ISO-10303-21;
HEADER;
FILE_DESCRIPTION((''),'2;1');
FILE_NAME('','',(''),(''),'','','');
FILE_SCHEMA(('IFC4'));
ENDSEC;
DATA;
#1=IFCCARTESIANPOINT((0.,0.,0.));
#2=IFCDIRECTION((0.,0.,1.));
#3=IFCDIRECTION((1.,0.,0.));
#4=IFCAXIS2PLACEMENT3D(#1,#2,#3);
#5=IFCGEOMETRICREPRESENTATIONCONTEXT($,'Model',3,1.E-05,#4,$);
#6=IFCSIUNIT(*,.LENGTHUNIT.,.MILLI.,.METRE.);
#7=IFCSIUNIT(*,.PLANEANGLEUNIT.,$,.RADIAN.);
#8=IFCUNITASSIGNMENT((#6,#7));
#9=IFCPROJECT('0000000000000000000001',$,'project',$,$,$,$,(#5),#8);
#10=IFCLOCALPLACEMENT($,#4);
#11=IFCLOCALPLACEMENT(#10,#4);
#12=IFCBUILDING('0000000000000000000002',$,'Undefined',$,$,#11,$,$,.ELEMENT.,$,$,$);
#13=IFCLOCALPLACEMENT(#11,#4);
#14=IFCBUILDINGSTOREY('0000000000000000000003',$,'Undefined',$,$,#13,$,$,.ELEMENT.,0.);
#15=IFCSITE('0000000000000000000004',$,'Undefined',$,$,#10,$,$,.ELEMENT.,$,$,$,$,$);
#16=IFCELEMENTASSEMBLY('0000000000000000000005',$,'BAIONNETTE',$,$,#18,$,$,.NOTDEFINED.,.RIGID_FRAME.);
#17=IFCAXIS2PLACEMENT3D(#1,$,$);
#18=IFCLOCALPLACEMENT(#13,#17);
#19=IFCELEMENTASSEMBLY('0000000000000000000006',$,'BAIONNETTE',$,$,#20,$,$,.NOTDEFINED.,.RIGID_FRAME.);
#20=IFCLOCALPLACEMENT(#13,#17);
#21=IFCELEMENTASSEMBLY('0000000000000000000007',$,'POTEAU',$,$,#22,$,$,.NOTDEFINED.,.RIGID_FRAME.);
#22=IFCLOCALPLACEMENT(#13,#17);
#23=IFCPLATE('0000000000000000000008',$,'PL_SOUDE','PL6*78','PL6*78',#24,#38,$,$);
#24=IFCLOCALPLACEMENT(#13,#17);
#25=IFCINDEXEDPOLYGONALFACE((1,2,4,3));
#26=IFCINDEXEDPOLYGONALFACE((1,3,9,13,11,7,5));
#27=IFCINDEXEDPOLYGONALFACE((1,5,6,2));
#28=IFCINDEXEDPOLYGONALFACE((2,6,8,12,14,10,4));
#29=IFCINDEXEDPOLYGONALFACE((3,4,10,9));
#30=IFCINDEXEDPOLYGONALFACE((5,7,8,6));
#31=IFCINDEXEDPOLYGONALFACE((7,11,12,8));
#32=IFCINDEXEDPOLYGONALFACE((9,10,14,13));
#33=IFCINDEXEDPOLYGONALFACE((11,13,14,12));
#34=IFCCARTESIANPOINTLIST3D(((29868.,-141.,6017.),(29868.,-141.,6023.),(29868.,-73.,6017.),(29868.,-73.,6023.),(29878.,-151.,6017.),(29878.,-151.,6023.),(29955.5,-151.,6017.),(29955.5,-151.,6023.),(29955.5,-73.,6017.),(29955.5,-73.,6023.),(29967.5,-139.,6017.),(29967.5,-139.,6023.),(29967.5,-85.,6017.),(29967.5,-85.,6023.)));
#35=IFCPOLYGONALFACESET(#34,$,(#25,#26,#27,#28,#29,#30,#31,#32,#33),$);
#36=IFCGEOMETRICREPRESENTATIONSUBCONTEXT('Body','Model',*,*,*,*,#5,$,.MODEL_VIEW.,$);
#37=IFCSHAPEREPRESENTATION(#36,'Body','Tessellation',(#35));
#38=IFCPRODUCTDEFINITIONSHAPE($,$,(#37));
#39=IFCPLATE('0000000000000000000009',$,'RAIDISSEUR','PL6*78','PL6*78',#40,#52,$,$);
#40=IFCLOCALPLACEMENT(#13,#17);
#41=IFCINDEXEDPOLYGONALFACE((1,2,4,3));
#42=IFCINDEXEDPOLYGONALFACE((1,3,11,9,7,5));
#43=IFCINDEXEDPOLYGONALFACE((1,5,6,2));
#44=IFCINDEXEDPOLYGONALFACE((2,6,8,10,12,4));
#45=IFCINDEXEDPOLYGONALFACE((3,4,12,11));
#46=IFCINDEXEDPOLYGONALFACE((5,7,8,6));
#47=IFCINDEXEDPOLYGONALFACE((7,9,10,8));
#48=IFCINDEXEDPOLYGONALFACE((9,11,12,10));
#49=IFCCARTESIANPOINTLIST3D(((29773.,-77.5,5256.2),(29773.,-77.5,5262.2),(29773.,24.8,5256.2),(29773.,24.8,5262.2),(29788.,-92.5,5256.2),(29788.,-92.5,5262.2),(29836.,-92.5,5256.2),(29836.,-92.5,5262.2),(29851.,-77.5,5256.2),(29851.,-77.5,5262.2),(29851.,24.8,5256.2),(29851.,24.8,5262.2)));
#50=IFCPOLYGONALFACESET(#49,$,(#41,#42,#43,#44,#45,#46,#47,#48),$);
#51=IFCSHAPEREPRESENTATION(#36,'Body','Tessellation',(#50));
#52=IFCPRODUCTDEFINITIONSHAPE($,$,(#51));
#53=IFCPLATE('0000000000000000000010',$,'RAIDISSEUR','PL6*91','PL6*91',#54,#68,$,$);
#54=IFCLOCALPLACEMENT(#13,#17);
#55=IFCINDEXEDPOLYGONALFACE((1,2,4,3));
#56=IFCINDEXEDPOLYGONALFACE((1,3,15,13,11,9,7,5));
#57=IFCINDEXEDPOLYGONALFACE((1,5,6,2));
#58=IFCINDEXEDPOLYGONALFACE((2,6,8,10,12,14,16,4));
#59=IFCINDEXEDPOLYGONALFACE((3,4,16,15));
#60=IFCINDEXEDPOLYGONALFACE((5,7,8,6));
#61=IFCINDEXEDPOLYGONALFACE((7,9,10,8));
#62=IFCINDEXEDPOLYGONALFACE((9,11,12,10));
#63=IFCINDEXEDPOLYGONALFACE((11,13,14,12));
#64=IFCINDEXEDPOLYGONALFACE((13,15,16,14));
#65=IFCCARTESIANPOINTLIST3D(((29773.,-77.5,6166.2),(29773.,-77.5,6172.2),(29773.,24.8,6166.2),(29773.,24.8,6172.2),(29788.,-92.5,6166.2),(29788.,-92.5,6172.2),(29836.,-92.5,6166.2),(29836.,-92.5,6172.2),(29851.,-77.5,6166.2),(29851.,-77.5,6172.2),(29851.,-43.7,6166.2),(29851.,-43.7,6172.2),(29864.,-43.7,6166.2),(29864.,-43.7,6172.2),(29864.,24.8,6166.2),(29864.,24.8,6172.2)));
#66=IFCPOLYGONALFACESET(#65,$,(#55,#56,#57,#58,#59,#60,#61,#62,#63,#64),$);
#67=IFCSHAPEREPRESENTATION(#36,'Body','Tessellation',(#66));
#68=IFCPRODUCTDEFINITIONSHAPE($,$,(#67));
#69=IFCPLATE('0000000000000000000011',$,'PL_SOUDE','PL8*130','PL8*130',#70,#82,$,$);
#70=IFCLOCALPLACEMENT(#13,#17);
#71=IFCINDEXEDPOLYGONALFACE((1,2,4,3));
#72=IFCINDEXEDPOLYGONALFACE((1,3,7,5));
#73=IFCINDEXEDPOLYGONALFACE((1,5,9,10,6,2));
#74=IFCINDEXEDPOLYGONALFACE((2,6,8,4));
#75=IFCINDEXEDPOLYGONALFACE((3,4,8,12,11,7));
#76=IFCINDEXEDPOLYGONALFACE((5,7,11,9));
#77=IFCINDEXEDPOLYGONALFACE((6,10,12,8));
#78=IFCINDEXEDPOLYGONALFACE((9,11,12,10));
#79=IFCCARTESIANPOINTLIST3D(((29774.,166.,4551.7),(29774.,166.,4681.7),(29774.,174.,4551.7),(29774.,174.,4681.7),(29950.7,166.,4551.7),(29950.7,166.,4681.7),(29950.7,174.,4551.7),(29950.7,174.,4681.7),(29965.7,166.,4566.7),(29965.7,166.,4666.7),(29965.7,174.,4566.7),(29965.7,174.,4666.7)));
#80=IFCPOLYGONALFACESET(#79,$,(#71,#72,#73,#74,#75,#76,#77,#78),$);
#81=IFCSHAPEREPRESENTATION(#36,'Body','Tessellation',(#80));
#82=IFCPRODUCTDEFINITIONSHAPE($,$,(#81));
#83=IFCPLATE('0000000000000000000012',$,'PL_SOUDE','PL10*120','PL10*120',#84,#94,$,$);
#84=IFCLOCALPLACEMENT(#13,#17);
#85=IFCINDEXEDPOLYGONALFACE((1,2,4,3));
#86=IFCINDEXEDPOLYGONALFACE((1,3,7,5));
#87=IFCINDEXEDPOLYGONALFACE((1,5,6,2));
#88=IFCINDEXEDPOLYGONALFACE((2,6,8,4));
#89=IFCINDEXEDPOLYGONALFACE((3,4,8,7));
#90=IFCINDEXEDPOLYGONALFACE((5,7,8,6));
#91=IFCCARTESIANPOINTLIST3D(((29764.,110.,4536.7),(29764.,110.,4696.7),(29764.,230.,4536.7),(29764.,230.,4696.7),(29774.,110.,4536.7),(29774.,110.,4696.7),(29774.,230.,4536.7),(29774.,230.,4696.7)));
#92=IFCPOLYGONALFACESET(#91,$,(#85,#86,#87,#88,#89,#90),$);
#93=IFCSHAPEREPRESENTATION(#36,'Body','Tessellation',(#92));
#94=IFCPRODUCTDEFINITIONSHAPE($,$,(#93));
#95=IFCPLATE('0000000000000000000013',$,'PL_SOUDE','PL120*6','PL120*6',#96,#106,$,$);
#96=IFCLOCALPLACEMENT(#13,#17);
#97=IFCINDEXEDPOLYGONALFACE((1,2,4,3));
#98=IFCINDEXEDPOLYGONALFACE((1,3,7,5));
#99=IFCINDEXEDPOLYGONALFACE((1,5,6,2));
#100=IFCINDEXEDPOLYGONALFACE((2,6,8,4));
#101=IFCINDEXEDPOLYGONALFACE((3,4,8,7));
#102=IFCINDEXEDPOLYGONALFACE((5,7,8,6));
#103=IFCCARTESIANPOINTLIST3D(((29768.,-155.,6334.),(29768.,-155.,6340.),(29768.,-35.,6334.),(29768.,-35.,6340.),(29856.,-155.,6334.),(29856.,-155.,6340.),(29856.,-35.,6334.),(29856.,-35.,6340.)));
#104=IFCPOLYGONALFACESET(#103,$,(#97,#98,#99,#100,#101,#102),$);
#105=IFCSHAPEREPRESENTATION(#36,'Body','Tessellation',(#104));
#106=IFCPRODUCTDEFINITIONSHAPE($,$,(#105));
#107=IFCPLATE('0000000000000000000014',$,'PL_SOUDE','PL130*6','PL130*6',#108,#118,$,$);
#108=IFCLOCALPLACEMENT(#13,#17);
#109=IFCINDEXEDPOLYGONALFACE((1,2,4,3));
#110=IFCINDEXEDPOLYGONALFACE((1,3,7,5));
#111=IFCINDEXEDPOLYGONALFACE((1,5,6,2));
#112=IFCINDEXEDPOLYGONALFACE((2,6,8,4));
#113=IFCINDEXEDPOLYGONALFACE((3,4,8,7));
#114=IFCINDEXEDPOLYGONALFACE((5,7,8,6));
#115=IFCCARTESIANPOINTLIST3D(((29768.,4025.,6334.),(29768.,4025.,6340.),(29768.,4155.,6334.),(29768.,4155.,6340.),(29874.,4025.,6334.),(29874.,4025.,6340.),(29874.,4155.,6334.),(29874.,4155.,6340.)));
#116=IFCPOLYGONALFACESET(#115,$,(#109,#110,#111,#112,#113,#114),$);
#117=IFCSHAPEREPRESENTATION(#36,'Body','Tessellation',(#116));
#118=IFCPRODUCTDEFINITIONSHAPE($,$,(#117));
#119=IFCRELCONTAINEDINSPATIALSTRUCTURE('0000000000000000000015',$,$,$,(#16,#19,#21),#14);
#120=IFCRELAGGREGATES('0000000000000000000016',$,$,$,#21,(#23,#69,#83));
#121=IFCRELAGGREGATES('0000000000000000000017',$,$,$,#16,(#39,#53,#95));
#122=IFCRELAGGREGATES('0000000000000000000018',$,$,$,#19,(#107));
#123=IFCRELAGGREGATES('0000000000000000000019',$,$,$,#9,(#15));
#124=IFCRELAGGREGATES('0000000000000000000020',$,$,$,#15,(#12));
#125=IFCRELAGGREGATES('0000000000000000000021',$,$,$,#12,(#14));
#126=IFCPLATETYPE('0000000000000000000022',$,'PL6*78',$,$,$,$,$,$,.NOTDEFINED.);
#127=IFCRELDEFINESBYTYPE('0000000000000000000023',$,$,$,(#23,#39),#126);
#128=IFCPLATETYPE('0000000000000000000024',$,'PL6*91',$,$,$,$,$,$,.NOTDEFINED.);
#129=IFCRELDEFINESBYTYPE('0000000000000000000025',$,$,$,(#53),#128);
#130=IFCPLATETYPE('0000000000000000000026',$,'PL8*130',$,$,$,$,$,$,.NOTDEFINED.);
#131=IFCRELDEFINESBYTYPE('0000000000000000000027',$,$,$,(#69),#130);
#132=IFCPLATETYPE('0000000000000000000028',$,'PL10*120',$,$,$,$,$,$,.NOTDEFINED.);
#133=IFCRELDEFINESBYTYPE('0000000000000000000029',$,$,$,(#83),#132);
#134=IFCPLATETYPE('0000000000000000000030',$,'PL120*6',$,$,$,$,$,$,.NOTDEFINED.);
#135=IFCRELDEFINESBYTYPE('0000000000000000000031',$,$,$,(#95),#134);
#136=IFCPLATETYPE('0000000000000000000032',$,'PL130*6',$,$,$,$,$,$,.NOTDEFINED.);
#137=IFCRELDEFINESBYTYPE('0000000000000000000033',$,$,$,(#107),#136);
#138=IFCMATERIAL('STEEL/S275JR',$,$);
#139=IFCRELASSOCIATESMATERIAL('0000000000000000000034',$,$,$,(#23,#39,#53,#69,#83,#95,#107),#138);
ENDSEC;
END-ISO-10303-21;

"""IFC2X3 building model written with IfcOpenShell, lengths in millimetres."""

from ifc_helpers import new_model, si_unit, frame, origin_with_axes, place, context, subcontext, project, spatial, polyline, outline, extrude, material, type_object, element, aggregate, save


model = new_model("IFC2X3")

# Units and contexts
model_context = context("Model", 3, precision=1e-05, world=origin_with_axes())
body_context = subcontext(model_context, "Body", "Model", "MODEL_VIEW")
ifc_project = project(units=[si_unit("LENGTHUNIT", "METRE", prefix="MILLI"), si_unit("PLANEANGLEUNIT", "RADIAN")], contexts=[model_context])

# Site, building, storey
site_placement = place(None, origin_with_axes())
site = spatial("IfcSite", under=ifc_project, at=site_placement, Name="Undefined", CompositionType="ELEMENT")
building_placement = place(site_placement, origin_with_axes())
building = spatial("IfcBuilding", under=site, at=building_placement, Name="Undefined", CompositionType="ELEMENT")
storey_placement = place(building_placement, origin_with_axes())
storey = spatial("IfcBuildingStorey", under=building, at=storey_placement, Name="Undefined", CompositionType="ELEMENT", Elevation=0.0)

# Shared definitions
ifc_material_1 = material(Name="STEEL/S275JR")

# Element assemblies
assembly_1_placement = place(storey_placement, origin_with_axes())
assembly_1 = element("IfcElementAssembly", 1, at=assembly_1_placement, inside=storey, Name="BAIONNETTE", AssemblyPlace="NOTDEFINED", PredefinedType="RIGID_FRAME")
assembly_2_placement = place(storey_placement, origin_with_axes())
assembly_2 = element("IfcElementAssembly", 2, at=assembly_2_placement, inside=storey, Name="BAIONNETTE", AssemblyPlace="NOTDEFINED", PredefinedType="RIGID_FRAME")

# Element assembly, plate
assembly_3_placement = place(storey_placement, origin_with_axes())
assembly_3 = element("IfcElementAssembly", 3, at=assembly_3_placement, inside=storey, Name="POTEAU", AssemblyPlace="NOTDEFINED", PredefinedType="RIGID_FRAME")
plate_type_1 = type_object("IfcPlateType", Name="PL6*78", PredefinedType="NOTDEFINED")
plate_1_placement = place(assembly_3_placement, frame((29868.0, -151.0, 6020.0), z_axis=(0.0, 0.0, 1.0), x_axis=(1.0, 0.0, 0.0)))
plate_1 = element("IfcPlate", 4, at=plate_1_placement, type_object=plate_type_1, material=ifc_material_1, Name="PL_SOUDE", Description="PL6*78", ObjectType="PL6*78", context=body_context, shape_type="SweptSolid", body=[
    extrude(outline(polyline([(0.0, 10.0), (10.0, 0.0), (87.5, 0.0), (99.5, 12.0), (99.5, 66.0), (87.5, 78.0), (0.0, 78.0), (0.0, 10.0)])), frame((0.0, 0.0, -3.0), z_axis=(0.0, 0.0, 1.0), x_axis=(1.0, 0.0, 0.0)), (0.0, 0.0, 1.0), 6.0),
])

# Plates
plate_2_placement = place(assembly_1_placement, frame((29851.0, -92.5, 5259.2), z_axis=(0.0, 0.0, 1.0), x_axis=(0.0, 1.0, 0.0)))
plate_2 = element("IfcPlate", 5, at=plate_2_placement, type_object=plate_type_1, material=ifc_material_1, Name="RAIDISSEUR", Description="PL6*78", ObjectType="PL6*78", context=body_context, shape_type="SweptSolid", body=[
    extrude(outline(polyline([(0.0, 15.0), (15.0, 0.0), (117.3, 0.0), (117.3, 78.0), (15.0, 78.0), (0.0, 63.0), (0.0, 15.0)])), frame((0.0, 0.0, -3.0), z_axis=(0.0, 0.0, 1.0), x_axis=(1.0, 0.0, 0.0)), (0.0, 0.0, 1.0), 6.0),
])
plate_type_2 = type_object("IfcPlateType", Name="PL6*91", PredefinedType="NOTDEFINED")
plate_3_placement = place(assembly_1_placement, frame((29851.0, -92.5, 6169.2), z_axis=(0.0, 0.0, 1.0), x_axis=(-0.000086, 1.0, 0.0)))
plate_3 = element("IfcPlate", 6, at=plate_3_placement, type_object=plate_type_2, material=ifc_material_1, Name="RAIDISSEUR", Description="PL6*91", ObjectType="PL6*91", context=body_context, shape_type="SweptSolid", body=[
    extrude(outline(polyline([(0.0, 15.0), (15.0, 0.0), (48.8, 0.0), (48.8, -13.0), (117.3, -13.0), (117.3, 78.0), (15.0, 78.0), (0.0, 63.0), (0.0, 15.0)])), frame((0.0, 0.0, -3.0), z_axis=(0.0, 0.0, 1.0), x_axis=(1.0, 0.0, 0.0)), (0.0, 0.0, 1.0), 6.0),
])
plate_type_3 = type_object("IfcPlateType", Name="PL8*130", PredefinedType="NOTDEFINED")
plate_4_placement = place(assembly_3_placement, frame((29774.0, 170.0, 4681.7), z_axis=(0.0, -1.0, 0.0), x_axis=(0.0, 0.0, -1.0)))
plate_4 = element("IfcPlate", 7, at=plate_4_placement, type_object=plate_type_3, material=ifc_material_1, Name="PL_SOUDE", Description="PL8*130", ObjectType="PL8*130", context=body_context, shape_type="SweptSolid", body=[
    extrude(outline(polyline([(0.0, 0.0), (130.0, 0.0), (130.0, 176.7), (115.0, 191.7), (15.0, 191.7), (0.0, 176.7), (0.0, 0.0)])), frame((0.0, 0.0, -4.0), z_axis=(0.0, 0.0, 1.0), x_axis=(1.0, 0.0, 0.0)), (0.0, 0.0, 1.0), 8.0),
])
plate_type_4 = type_object("IfcPlateType", Name="PL10*120", PredefinedType="NOTDEFINED")
plate_5_placement = place(assembly_3_placement, frame((29769.0, 170.0, 4696.7), z_axis=(1.0, 0.0, 0.0), x_axis=(0.0, 0.0, -1.0)))
plate_5 = element("IfcPlate", 8, at=plate_5_placement, type_object=plate_type_4, material=ifc_material_1, Name="PL_SOUDE", Description="PL10*120", ObjectType="PL10*120", context=body_context, shape_type="SweptSolid", body=[
    extrude(outline(polyline([(160.0, -60.0), (0.0, -60.0), (0.0, 60.0), (160.0, 60.0), (160.0, -60.0)])), frame((0.0, 0.0, -5.0), z_axis=(0.0, 0.0, 1.0), x_axis=(1.0, 0.0, 0.0)), (0.0, 0.0, 1.0), 10.0),
])
plate_type_5 = type_object("IfcPlateType", Name="PL120*6", PredefinedType="NOTDEFINED")
plate_6_placement = place(assembly_1_placement, frame((29768.0, -95.0, 6337.0), z_axis=(0.0, 0.0, 1.0), x_axis=(1.0, 0.0, 0.0)))
plate_6 = element("IfcPlate", 9, at=plate_6_placement, type_object=plate_type_5, material=ifc_material_1, Name="PL_SOUDE", Description="PL120*6", ObjectType="PL120*6", context=body_context, shape_type="SweptSolid", body=[
    extrude(outline(polyline([(0.0, -60.0), (0.0, 60.0), (88.0, 60.0), (88.0, -60.0), (0.0, -60.0)])), frame((0.0, 0.0, -3.0), z_axis=(0.0, 0.0, 1.0), x_axis=(1.0, 0.0, 0.0)), (0.0, 0.0, 1.0), 6.0),
])
plate_type_6 = type_object("IfcPlateType", Name="PL130*6", PredefinedType="NOTDEFINED")
plate_7_placement = place(assembly_2_placement, frame((29768.0, 4090.0, 6337.0), z_axis=(0.0, 0.0, 1.0), x_axis=(1.0, 0.0, 0.0)))
plate_7 = element("IfcPlate", 10, at=plate_7_placement, type_object=plate_type_6, material=ifc_material_1, Name="PL_SOUDE", Description="PL130*6", ObjectType="PL130*6", context=body_context, shape_type="SweptSolid", body=[
    extrude(outline(polyline([(0.0, -65.0), (0.0, 65.0), (106.0, 65.0), (106.0, -65.0), (0.0, -65.0)])), frame((0.0, 0.0, -3.0), z_axis=(0.0, 0.0, 1.0), x_axis=(1.0, 0.0, 0.0)), (0.0, 0.0, 1.0), 6.0),
])

aggregate(assembly_3, [plate_1, plate_4, plate_5])

aggregate(assembly_1, [plate_2, plate_3, plate_6])
aggregate(assembly_2, [plate_7])

save(model, "model.ifc")
